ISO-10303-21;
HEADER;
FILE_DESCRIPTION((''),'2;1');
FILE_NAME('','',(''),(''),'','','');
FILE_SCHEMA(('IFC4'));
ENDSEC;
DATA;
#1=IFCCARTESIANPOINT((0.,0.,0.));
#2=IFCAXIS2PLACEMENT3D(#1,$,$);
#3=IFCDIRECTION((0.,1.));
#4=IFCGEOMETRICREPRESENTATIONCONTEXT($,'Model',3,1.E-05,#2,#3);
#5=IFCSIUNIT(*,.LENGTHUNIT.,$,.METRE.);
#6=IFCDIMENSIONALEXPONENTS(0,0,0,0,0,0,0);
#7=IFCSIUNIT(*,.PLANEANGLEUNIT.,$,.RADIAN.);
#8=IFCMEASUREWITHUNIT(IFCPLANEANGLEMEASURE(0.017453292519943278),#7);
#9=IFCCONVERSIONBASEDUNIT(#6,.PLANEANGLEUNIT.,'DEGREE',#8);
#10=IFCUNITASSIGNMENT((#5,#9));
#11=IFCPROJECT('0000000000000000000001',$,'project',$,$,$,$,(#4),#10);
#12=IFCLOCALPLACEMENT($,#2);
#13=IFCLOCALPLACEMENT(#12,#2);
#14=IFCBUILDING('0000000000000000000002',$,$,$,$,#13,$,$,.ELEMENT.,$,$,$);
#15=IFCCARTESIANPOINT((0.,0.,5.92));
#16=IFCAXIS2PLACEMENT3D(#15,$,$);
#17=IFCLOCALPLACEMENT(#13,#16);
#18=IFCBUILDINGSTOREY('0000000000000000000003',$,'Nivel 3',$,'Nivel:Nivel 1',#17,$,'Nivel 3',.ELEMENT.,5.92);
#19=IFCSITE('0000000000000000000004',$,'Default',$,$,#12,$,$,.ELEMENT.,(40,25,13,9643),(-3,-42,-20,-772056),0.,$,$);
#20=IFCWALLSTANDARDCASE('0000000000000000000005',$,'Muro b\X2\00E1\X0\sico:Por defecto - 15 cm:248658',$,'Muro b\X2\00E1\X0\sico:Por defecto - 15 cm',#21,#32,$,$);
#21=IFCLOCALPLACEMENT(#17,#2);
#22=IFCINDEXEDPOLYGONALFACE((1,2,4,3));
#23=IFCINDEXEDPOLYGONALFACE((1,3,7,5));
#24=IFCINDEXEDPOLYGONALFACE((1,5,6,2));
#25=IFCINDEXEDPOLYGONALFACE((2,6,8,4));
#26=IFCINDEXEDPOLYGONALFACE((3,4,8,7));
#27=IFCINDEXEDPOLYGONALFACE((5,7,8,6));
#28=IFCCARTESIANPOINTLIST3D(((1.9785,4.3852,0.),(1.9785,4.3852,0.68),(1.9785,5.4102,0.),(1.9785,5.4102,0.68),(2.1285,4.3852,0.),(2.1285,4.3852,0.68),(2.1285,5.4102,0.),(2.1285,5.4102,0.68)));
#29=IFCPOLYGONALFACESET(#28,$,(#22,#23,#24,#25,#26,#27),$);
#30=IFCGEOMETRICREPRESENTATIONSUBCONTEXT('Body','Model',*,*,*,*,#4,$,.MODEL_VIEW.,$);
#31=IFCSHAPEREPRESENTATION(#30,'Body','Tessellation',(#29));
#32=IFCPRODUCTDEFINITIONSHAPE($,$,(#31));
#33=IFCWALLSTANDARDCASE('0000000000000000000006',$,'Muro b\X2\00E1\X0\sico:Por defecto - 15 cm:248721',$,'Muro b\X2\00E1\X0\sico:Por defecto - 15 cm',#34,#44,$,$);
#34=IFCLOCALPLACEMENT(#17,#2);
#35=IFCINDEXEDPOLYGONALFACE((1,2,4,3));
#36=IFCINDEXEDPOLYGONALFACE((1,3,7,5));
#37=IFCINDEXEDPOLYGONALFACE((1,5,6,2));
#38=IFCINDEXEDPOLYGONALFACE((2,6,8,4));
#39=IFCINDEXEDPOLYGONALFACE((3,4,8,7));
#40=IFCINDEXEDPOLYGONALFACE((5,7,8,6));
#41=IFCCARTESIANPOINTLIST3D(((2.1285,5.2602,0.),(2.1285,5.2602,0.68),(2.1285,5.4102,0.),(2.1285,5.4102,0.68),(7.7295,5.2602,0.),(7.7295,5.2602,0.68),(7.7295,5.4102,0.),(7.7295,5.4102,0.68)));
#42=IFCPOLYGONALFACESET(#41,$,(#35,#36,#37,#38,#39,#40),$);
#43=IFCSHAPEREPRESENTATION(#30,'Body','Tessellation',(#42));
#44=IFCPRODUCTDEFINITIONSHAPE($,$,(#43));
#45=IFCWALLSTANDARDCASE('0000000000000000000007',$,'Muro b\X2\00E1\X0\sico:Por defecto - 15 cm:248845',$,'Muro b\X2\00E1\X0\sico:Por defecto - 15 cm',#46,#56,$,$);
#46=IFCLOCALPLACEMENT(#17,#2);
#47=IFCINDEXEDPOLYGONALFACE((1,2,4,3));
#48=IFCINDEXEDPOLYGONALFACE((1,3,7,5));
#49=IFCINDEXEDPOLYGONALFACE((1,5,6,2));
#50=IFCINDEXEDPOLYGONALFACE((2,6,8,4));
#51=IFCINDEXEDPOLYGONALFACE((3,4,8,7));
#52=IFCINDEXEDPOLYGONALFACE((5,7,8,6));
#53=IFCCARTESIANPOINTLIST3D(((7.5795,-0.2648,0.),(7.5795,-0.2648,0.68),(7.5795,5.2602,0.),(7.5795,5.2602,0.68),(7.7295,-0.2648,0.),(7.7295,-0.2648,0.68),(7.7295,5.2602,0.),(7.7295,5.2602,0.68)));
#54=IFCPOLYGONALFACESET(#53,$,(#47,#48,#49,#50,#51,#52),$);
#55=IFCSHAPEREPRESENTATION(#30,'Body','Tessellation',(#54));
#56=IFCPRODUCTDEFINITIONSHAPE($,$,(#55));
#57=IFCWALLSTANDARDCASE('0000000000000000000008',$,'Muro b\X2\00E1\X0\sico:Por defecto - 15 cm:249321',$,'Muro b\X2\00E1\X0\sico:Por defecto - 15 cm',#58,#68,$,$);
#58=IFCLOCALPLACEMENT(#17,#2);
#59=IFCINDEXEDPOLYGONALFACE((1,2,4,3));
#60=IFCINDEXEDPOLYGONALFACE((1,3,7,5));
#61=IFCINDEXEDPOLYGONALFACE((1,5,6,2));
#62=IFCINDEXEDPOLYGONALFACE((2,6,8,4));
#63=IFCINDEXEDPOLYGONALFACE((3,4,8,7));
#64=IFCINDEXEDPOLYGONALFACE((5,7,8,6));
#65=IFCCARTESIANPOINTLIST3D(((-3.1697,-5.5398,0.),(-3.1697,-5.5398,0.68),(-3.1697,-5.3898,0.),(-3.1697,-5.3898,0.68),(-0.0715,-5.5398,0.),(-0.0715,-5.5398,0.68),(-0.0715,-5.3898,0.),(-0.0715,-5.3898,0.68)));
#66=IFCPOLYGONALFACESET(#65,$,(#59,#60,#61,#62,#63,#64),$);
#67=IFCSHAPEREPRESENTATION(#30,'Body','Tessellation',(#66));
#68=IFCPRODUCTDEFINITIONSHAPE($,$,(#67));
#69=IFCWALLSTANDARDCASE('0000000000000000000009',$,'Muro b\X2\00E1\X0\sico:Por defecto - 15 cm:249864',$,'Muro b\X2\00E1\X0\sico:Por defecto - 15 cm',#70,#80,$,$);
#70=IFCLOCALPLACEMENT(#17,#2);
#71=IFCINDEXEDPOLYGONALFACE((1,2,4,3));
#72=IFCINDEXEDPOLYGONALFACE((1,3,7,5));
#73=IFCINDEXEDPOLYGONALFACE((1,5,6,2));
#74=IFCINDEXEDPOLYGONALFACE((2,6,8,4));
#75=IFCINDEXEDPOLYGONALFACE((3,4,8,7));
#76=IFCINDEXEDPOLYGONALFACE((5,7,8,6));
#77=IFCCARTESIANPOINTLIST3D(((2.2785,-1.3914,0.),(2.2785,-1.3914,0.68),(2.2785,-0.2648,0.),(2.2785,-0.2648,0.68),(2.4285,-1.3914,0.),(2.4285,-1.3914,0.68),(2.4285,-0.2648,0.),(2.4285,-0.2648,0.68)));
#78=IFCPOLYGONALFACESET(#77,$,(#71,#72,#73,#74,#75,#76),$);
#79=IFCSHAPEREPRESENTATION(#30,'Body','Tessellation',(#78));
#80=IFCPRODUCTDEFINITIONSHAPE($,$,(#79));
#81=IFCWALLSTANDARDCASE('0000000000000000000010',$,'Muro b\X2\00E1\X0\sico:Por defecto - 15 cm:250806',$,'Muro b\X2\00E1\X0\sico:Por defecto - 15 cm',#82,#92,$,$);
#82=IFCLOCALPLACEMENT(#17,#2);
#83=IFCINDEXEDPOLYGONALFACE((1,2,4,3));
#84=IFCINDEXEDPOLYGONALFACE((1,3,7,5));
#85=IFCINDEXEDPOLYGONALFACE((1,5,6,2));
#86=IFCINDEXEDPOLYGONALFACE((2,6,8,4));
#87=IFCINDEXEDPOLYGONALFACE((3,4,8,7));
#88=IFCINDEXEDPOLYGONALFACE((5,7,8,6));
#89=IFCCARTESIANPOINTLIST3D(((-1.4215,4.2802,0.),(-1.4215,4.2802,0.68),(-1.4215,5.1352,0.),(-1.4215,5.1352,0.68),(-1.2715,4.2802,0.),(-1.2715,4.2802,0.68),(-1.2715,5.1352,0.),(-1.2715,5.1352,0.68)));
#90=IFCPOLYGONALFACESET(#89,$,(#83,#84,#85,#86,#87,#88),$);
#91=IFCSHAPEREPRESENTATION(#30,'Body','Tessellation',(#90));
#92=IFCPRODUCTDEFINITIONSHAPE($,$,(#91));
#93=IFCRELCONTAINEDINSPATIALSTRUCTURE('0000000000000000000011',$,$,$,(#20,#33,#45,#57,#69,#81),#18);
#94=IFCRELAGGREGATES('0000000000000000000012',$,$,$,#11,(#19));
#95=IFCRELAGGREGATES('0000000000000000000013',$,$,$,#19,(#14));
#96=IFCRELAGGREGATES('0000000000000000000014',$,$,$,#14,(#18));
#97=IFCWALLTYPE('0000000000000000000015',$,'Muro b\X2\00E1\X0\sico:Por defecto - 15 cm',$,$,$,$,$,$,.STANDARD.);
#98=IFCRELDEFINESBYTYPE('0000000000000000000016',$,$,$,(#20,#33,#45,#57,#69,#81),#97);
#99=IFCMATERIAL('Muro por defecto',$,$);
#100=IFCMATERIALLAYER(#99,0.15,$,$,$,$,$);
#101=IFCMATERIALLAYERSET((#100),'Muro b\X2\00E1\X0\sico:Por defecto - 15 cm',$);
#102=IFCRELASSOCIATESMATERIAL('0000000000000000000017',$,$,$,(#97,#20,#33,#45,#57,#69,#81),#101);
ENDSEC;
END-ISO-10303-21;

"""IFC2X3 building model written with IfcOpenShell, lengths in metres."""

from ifc_helpers import new_model, entity, si_unit, converted_unit, direction, frame, frame_2d, origin, place, context, subcontext, project, spatial, rectangle, extrude, material, layer, layer_set, layer_usage, type_object, element, save


model = new_model("IFC2X3")

# Units and contexts
model_context = context("Model", 3, precision=1e-05, world=origin(), true_north=direction((0.0, 1.0)))
body_context = subcontext(model_context, "Body", "Model", "MODEL_VIEW")
ifc_project = project(units=[si_unit("LENGTHUNIT", "METRE"), converted_unit("PLANEANGLEUNIT", "DEGREE", entity("IfcPlaneAngleMeasure", 0.017453292519943278), si_unit("PLANEANGLEUNIT", "RADIAN"), dimensions=[0, 0, 0, 0, 0, 0, 0])], contexts=[model_context])

# Site, building, storey
site_placement = place(None, origin())
site = spatial("IfcSite", under=ifc_project, at=site_placement, Name="Default", CompositionType="ELEMENT", RefLatitude=(40, 25, 13, 9643), RefLongitude=(-3, -42, -20, -772056), RefElevation=0.0)
building_placement = place(site_placement, origin())
building = spatial("IfcBuilding", under=site, at=building_placement, CompositionType="ELEMENT")
storey_placement = place(building_placement, frame((0.0, 0.0, 5.92)))
storey = spatial("IfcBuildingStorey", under=building, at=storey_placement, Name="Nivel 3", ObjectType="Nivel:Nivel 1", LongName="Nivel 3", CompositionType="ELEMENT", Elevation=5.92)

# Walls
ifc_material_1 = material(Name="Muro por defecto")
ifc_layer_1 = layer(ifc_material_1, 0.15)
ifc_layer_set_1 = layer_set([ifc_layer_1], Name="Muro básico:Por defecto - 15 cm")
wall_type = type_object("IfcWallType", Name="Muro básico:Por defecto - 15 cm", PredefinedType="STANDARD", material=ifc_layer_set_1)
ifc_layer_usage_1 = layer_usage(ifc_layer_set_1, "AXIS2", "NEGATIVE", 0.075)
wall_1_placement = place(storey_placement, frame((2.0535, 4.3852, 0.0), z_axis=(0.0, 0.0, 1.0), x_axis=(0.0, 1.0, 0.0)))
element("IfcWallStandardCase", 1, at=wall_1_placement, inside=storey, type_object=wall_type, material=ifc_layer_usage_1, Name="Muro básico:Por defecto - 15 cm:248658", ObjectType="Muro básico:Por defecto - 15 cm", context=body_context, shape_type="SweptSolid", body=[
    extrude(rectangle(XDim=1.025, YDim=0.15, at=frame_2d((0.5125, 0.0), x_axis=(-1.0, 0.0))), origin(), (0.0, 0.0, 1.0), 0.68),
])
ifc_layer_usage_2 = layer_usage(ifc_layer_set_1, "AXIS2", "NEGATIVE", 0.075)
wall_2_placement = place(storey_placement, frame((2.1285, 5.3352, 0.0)))
element("IfcWallStandardCase", 2, at=wall_2_placement, inside=storey, type_object=wall_type, material=ifc_layer_usage_2, Name="Muro básico:Por defecto - 15 cm:248721", ObjectType="Muro básico:Por defecto - 15 cm", context=body_context, shape_type="SweptSolid", body=[
    extrude(rectangle(XDim=5.601, YDim=0.15, at=frame_2d((2.8005, 0.0), x_axis=(-1.0, 0.0))), origin(), (0.0, 0.0, 1.0), 0.68),
])
ifc_layer_usage_3 = layer_usage(ifc_layer_set_1, "AXIS2", "NEGATIVE", 0.075)
wall_3_placement = place(storey_placement, frame((7.6545, 5.2602, 0.0), z_axis=(0.0, 0.0, 1.0), x_axis=(0.0, -1.0, 0.0)))
element("IfcWallStandardCase", 3, at=wall_3_placement, inside=storey, type_object=wall_type, material=ifc_layer_usage_3, Name="Muro básico:Por defecto - 15 cm:248845", ObjectType="Muro básico:Por defecto - 15 cm", context=body_context, shape_type="SweptSolid", body=[
    extrude(rectangle(XDim=5.525, YDim=0.15, at=frame_2d((2.7625, 0.0), x_axis=(-1.0, 0.0))), origin(), (0.0, 0.0, 1.0), 0.68),
])
ifc_layer_usage_4 = layer_usage(ifc_layer_set_1, "AXIS2", "NEGATIVE", 0.075)
wall_4_placement = place(storey_placement, frame((-0.0715, -5.4648, 0.0), z_axis=(0.0, 0.0, 1.0), x_axis=(-1.0, 0.0, 0.0)))
element("IfcWallStandardCase", 4, at=wall_4_placement, inside=storey, type_object=wall_type, material=ifc_layer_usage_4, Name="Muro básico:Por defecto - 15 cm:249321", ObjectType="Muro básico:Por defecto - 15 cm", context=body_context, shape_type="SweptSolid", body=[
    extrude(rectangle(XDim=3.0982, YDim=0.15, at=frame_2d((1.5491, 0.0), x_axis=(-1.0, 0.0))), origin(), (0.0, 0.0, 1.0), 0.68),
])
ifc_layer_usage_5 = layer_usage(ifc_layer_set_1, "AXIS2", "POSITIVE", -0.075)
wall_5_placement = place(storey_placement, frame((2.3535, -1.3914, 0.0), z_axis=(0.0, 0.0, 1.0), x_axis=(0.0, 1.0, 0.0)))
element("IfcWallStandardCase", 5, at=wall_5_placement, inside=storey, type_object=wall_type, material=ifc_layer_usage_5, Name="Muro básico:Por defecto - 15 cm:249864", ObjectType="Muro básico:Por defecto - 15 cm", context=body_context, shape_type="SweptSolid", body=[
    extrude(rectangle(XDim=1.1266, YDim=0.15, at=frame_2d((0.5633, 0.0), x_axis=(-1.0, 0.0))), origin(), (0.0, 0.0, 1.0), 0.68),
])
ifc_layer_usage_6 = layer_usage(ifc_layer_set_1, "AXIS2", "NEGATIVE", 0.075)
wall_6_placement = place(storey_placement, frame((-1.3465, 4.2802, 0.0), z_axis=(0.0, 0.0, 1.0), x_axis=(0.0, 1.0, 0.0)))
element("IfcWallStandardCase", 6, at=wall_6_placement, inside=storey, type_object=wall_type, material=ifc_layer_usage_6, Name="Muro básico:Por defecto - 15 cm:250806", ObjectType="Muro básico:Por defecto - 15 cm", context=body_context, shape_type="SweptSolid", body=[
    extrude(rectangle(XDim=0.855, YDim=0.15, at=frame_2d((0.4275, 0.0), x_axis=(-1.0, 0.0))), origin(), (0.0, 0.0, 1.0), 0.68),
])

save(model, "model.ifc")
